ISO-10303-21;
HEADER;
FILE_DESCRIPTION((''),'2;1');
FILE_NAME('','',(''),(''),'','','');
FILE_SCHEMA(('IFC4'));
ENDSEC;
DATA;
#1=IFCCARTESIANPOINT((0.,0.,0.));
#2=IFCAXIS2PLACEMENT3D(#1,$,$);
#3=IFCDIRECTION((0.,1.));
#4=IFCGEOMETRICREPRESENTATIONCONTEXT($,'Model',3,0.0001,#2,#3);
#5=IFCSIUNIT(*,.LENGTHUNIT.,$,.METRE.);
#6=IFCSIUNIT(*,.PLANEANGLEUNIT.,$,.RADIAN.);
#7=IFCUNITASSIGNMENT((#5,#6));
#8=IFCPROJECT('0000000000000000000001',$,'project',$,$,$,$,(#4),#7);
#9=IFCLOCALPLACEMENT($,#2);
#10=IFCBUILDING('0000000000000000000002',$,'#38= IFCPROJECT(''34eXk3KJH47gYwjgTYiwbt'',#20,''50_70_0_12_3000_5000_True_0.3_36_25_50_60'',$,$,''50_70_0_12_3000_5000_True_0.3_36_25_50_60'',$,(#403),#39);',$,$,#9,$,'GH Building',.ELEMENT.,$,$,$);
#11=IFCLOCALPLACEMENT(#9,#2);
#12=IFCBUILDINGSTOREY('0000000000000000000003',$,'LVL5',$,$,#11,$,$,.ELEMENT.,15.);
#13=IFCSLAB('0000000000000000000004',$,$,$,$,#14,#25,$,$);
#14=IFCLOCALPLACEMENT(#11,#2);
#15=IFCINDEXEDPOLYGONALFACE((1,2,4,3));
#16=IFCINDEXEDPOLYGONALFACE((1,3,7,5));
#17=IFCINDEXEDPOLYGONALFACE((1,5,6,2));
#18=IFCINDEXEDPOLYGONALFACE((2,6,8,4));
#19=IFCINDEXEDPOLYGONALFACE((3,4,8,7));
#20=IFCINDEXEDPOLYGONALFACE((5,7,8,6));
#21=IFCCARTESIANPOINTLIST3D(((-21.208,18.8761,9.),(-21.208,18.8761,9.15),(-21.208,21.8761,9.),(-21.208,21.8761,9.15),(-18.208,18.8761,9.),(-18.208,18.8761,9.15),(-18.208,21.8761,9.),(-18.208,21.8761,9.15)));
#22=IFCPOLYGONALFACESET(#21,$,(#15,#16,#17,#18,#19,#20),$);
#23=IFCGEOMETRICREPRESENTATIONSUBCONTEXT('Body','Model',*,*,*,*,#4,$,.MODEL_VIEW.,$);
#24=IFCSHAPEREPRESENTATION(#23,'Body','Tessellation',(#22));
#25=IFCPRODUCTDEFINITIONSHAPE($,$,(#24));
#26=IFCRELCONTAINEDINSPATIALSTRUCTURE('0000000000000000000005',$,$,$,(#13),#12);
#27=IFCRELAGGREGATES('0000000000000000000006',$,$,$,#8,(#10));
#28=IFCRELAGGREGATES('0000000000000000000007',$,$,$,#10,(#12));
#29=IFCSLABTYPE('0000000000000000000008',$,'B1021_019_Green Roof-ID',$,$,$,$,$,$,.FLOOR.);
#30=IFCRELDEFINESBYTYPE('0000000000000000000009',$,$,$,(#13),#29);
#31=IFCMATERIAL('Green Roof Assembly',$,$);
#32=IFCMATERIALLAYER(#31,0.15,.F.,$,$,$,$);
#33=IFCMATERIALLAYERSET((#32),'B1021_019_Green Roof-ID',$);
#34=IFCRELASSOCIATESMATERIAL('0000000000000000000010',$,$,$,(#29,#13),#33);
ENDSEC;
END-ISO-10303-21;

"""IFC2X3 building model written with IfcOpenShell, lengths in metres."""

from ifc_helpers import new_model, si_unit, direction, frame, origin, place, context, subcontext, project, spatial, polyline, outline, extrude, material, layer, layer_set, layer_usage, type_object, element, save


model = new_model("IFC2X3")

# Units and contexts
model_context = context("Model", 3, precision=0.0001, world=origin(), true_north=direction((0.0, 1.0)))
body_context = subcontext(model_context, "Body", "Model", "MODEL_VIEW")
ifc_project = project(units=[si_unit("LENGTHUNIT", "METRE"), si_unit("PLANEANGLEUNIT", "RADIAN")], contexts=[model_context])

# Building, storey
building_placement = place(None, origin())
building = spatial("IfcBuilding", under=ifc_project, at=building_placement, Name="#38= IFCPROJECT('34eXk3KJH47gYwjgTYiwbt',#20,'50_70_0_12_3000_5000_True_0.3_36_25_50_60',$,$,'50_70_0_12_3000_5000_True_0.3_36_25_50_60',$,(#403),#39);", LongName="GH Building", CompositionType="ELEMENT")
storey_placement = place(building_placement, origin())
storey = spatial("IfcBuildingStorey", under=building, at=storey_placement, Name="LVL5", CompositionType="ELEMENT", Elevation=15.0)

# Slab
ifc_material_1 = material(Name="Green Roof Assembly")
ifc_layer_1 = layer(ifc_material_1, 0.15, ventilated=False)
ifc_layer_set_1 = layer_set([ifc_layer_1], Name="B1021_019_Green Roof-ID")
slab_type_1 = type_object("IfcSlabType", Name="B1021_019_Green Roof-ID", PredefinedType="FLOOR", material=ifc_layer_set_1)
ifc_layer_usage_1 = layer_usage(ifc_layer_set_1, "AXIS3", "NEGATIVE", -0.15)
slab_1_placement = place(storey_placement, frame((-19.708, 20.3761, 9.0)))
element("IfcSlab", 1, at=slab_1_placement, inside=storey, type_object=slab_type_1, material=ifc_layer_usage_1, context=body_context, shape_type="SweptSolid", body=[
    extrude(outline(polyline([(1.5, -1.5), (-1.5, -1.5), (-1.5, 1.5), (1.5, 1.5), (1.5, -1.5)])), origin(), (0.0, 0.0, 1.0), 0.15),
])

save(model, "model.ifc")
